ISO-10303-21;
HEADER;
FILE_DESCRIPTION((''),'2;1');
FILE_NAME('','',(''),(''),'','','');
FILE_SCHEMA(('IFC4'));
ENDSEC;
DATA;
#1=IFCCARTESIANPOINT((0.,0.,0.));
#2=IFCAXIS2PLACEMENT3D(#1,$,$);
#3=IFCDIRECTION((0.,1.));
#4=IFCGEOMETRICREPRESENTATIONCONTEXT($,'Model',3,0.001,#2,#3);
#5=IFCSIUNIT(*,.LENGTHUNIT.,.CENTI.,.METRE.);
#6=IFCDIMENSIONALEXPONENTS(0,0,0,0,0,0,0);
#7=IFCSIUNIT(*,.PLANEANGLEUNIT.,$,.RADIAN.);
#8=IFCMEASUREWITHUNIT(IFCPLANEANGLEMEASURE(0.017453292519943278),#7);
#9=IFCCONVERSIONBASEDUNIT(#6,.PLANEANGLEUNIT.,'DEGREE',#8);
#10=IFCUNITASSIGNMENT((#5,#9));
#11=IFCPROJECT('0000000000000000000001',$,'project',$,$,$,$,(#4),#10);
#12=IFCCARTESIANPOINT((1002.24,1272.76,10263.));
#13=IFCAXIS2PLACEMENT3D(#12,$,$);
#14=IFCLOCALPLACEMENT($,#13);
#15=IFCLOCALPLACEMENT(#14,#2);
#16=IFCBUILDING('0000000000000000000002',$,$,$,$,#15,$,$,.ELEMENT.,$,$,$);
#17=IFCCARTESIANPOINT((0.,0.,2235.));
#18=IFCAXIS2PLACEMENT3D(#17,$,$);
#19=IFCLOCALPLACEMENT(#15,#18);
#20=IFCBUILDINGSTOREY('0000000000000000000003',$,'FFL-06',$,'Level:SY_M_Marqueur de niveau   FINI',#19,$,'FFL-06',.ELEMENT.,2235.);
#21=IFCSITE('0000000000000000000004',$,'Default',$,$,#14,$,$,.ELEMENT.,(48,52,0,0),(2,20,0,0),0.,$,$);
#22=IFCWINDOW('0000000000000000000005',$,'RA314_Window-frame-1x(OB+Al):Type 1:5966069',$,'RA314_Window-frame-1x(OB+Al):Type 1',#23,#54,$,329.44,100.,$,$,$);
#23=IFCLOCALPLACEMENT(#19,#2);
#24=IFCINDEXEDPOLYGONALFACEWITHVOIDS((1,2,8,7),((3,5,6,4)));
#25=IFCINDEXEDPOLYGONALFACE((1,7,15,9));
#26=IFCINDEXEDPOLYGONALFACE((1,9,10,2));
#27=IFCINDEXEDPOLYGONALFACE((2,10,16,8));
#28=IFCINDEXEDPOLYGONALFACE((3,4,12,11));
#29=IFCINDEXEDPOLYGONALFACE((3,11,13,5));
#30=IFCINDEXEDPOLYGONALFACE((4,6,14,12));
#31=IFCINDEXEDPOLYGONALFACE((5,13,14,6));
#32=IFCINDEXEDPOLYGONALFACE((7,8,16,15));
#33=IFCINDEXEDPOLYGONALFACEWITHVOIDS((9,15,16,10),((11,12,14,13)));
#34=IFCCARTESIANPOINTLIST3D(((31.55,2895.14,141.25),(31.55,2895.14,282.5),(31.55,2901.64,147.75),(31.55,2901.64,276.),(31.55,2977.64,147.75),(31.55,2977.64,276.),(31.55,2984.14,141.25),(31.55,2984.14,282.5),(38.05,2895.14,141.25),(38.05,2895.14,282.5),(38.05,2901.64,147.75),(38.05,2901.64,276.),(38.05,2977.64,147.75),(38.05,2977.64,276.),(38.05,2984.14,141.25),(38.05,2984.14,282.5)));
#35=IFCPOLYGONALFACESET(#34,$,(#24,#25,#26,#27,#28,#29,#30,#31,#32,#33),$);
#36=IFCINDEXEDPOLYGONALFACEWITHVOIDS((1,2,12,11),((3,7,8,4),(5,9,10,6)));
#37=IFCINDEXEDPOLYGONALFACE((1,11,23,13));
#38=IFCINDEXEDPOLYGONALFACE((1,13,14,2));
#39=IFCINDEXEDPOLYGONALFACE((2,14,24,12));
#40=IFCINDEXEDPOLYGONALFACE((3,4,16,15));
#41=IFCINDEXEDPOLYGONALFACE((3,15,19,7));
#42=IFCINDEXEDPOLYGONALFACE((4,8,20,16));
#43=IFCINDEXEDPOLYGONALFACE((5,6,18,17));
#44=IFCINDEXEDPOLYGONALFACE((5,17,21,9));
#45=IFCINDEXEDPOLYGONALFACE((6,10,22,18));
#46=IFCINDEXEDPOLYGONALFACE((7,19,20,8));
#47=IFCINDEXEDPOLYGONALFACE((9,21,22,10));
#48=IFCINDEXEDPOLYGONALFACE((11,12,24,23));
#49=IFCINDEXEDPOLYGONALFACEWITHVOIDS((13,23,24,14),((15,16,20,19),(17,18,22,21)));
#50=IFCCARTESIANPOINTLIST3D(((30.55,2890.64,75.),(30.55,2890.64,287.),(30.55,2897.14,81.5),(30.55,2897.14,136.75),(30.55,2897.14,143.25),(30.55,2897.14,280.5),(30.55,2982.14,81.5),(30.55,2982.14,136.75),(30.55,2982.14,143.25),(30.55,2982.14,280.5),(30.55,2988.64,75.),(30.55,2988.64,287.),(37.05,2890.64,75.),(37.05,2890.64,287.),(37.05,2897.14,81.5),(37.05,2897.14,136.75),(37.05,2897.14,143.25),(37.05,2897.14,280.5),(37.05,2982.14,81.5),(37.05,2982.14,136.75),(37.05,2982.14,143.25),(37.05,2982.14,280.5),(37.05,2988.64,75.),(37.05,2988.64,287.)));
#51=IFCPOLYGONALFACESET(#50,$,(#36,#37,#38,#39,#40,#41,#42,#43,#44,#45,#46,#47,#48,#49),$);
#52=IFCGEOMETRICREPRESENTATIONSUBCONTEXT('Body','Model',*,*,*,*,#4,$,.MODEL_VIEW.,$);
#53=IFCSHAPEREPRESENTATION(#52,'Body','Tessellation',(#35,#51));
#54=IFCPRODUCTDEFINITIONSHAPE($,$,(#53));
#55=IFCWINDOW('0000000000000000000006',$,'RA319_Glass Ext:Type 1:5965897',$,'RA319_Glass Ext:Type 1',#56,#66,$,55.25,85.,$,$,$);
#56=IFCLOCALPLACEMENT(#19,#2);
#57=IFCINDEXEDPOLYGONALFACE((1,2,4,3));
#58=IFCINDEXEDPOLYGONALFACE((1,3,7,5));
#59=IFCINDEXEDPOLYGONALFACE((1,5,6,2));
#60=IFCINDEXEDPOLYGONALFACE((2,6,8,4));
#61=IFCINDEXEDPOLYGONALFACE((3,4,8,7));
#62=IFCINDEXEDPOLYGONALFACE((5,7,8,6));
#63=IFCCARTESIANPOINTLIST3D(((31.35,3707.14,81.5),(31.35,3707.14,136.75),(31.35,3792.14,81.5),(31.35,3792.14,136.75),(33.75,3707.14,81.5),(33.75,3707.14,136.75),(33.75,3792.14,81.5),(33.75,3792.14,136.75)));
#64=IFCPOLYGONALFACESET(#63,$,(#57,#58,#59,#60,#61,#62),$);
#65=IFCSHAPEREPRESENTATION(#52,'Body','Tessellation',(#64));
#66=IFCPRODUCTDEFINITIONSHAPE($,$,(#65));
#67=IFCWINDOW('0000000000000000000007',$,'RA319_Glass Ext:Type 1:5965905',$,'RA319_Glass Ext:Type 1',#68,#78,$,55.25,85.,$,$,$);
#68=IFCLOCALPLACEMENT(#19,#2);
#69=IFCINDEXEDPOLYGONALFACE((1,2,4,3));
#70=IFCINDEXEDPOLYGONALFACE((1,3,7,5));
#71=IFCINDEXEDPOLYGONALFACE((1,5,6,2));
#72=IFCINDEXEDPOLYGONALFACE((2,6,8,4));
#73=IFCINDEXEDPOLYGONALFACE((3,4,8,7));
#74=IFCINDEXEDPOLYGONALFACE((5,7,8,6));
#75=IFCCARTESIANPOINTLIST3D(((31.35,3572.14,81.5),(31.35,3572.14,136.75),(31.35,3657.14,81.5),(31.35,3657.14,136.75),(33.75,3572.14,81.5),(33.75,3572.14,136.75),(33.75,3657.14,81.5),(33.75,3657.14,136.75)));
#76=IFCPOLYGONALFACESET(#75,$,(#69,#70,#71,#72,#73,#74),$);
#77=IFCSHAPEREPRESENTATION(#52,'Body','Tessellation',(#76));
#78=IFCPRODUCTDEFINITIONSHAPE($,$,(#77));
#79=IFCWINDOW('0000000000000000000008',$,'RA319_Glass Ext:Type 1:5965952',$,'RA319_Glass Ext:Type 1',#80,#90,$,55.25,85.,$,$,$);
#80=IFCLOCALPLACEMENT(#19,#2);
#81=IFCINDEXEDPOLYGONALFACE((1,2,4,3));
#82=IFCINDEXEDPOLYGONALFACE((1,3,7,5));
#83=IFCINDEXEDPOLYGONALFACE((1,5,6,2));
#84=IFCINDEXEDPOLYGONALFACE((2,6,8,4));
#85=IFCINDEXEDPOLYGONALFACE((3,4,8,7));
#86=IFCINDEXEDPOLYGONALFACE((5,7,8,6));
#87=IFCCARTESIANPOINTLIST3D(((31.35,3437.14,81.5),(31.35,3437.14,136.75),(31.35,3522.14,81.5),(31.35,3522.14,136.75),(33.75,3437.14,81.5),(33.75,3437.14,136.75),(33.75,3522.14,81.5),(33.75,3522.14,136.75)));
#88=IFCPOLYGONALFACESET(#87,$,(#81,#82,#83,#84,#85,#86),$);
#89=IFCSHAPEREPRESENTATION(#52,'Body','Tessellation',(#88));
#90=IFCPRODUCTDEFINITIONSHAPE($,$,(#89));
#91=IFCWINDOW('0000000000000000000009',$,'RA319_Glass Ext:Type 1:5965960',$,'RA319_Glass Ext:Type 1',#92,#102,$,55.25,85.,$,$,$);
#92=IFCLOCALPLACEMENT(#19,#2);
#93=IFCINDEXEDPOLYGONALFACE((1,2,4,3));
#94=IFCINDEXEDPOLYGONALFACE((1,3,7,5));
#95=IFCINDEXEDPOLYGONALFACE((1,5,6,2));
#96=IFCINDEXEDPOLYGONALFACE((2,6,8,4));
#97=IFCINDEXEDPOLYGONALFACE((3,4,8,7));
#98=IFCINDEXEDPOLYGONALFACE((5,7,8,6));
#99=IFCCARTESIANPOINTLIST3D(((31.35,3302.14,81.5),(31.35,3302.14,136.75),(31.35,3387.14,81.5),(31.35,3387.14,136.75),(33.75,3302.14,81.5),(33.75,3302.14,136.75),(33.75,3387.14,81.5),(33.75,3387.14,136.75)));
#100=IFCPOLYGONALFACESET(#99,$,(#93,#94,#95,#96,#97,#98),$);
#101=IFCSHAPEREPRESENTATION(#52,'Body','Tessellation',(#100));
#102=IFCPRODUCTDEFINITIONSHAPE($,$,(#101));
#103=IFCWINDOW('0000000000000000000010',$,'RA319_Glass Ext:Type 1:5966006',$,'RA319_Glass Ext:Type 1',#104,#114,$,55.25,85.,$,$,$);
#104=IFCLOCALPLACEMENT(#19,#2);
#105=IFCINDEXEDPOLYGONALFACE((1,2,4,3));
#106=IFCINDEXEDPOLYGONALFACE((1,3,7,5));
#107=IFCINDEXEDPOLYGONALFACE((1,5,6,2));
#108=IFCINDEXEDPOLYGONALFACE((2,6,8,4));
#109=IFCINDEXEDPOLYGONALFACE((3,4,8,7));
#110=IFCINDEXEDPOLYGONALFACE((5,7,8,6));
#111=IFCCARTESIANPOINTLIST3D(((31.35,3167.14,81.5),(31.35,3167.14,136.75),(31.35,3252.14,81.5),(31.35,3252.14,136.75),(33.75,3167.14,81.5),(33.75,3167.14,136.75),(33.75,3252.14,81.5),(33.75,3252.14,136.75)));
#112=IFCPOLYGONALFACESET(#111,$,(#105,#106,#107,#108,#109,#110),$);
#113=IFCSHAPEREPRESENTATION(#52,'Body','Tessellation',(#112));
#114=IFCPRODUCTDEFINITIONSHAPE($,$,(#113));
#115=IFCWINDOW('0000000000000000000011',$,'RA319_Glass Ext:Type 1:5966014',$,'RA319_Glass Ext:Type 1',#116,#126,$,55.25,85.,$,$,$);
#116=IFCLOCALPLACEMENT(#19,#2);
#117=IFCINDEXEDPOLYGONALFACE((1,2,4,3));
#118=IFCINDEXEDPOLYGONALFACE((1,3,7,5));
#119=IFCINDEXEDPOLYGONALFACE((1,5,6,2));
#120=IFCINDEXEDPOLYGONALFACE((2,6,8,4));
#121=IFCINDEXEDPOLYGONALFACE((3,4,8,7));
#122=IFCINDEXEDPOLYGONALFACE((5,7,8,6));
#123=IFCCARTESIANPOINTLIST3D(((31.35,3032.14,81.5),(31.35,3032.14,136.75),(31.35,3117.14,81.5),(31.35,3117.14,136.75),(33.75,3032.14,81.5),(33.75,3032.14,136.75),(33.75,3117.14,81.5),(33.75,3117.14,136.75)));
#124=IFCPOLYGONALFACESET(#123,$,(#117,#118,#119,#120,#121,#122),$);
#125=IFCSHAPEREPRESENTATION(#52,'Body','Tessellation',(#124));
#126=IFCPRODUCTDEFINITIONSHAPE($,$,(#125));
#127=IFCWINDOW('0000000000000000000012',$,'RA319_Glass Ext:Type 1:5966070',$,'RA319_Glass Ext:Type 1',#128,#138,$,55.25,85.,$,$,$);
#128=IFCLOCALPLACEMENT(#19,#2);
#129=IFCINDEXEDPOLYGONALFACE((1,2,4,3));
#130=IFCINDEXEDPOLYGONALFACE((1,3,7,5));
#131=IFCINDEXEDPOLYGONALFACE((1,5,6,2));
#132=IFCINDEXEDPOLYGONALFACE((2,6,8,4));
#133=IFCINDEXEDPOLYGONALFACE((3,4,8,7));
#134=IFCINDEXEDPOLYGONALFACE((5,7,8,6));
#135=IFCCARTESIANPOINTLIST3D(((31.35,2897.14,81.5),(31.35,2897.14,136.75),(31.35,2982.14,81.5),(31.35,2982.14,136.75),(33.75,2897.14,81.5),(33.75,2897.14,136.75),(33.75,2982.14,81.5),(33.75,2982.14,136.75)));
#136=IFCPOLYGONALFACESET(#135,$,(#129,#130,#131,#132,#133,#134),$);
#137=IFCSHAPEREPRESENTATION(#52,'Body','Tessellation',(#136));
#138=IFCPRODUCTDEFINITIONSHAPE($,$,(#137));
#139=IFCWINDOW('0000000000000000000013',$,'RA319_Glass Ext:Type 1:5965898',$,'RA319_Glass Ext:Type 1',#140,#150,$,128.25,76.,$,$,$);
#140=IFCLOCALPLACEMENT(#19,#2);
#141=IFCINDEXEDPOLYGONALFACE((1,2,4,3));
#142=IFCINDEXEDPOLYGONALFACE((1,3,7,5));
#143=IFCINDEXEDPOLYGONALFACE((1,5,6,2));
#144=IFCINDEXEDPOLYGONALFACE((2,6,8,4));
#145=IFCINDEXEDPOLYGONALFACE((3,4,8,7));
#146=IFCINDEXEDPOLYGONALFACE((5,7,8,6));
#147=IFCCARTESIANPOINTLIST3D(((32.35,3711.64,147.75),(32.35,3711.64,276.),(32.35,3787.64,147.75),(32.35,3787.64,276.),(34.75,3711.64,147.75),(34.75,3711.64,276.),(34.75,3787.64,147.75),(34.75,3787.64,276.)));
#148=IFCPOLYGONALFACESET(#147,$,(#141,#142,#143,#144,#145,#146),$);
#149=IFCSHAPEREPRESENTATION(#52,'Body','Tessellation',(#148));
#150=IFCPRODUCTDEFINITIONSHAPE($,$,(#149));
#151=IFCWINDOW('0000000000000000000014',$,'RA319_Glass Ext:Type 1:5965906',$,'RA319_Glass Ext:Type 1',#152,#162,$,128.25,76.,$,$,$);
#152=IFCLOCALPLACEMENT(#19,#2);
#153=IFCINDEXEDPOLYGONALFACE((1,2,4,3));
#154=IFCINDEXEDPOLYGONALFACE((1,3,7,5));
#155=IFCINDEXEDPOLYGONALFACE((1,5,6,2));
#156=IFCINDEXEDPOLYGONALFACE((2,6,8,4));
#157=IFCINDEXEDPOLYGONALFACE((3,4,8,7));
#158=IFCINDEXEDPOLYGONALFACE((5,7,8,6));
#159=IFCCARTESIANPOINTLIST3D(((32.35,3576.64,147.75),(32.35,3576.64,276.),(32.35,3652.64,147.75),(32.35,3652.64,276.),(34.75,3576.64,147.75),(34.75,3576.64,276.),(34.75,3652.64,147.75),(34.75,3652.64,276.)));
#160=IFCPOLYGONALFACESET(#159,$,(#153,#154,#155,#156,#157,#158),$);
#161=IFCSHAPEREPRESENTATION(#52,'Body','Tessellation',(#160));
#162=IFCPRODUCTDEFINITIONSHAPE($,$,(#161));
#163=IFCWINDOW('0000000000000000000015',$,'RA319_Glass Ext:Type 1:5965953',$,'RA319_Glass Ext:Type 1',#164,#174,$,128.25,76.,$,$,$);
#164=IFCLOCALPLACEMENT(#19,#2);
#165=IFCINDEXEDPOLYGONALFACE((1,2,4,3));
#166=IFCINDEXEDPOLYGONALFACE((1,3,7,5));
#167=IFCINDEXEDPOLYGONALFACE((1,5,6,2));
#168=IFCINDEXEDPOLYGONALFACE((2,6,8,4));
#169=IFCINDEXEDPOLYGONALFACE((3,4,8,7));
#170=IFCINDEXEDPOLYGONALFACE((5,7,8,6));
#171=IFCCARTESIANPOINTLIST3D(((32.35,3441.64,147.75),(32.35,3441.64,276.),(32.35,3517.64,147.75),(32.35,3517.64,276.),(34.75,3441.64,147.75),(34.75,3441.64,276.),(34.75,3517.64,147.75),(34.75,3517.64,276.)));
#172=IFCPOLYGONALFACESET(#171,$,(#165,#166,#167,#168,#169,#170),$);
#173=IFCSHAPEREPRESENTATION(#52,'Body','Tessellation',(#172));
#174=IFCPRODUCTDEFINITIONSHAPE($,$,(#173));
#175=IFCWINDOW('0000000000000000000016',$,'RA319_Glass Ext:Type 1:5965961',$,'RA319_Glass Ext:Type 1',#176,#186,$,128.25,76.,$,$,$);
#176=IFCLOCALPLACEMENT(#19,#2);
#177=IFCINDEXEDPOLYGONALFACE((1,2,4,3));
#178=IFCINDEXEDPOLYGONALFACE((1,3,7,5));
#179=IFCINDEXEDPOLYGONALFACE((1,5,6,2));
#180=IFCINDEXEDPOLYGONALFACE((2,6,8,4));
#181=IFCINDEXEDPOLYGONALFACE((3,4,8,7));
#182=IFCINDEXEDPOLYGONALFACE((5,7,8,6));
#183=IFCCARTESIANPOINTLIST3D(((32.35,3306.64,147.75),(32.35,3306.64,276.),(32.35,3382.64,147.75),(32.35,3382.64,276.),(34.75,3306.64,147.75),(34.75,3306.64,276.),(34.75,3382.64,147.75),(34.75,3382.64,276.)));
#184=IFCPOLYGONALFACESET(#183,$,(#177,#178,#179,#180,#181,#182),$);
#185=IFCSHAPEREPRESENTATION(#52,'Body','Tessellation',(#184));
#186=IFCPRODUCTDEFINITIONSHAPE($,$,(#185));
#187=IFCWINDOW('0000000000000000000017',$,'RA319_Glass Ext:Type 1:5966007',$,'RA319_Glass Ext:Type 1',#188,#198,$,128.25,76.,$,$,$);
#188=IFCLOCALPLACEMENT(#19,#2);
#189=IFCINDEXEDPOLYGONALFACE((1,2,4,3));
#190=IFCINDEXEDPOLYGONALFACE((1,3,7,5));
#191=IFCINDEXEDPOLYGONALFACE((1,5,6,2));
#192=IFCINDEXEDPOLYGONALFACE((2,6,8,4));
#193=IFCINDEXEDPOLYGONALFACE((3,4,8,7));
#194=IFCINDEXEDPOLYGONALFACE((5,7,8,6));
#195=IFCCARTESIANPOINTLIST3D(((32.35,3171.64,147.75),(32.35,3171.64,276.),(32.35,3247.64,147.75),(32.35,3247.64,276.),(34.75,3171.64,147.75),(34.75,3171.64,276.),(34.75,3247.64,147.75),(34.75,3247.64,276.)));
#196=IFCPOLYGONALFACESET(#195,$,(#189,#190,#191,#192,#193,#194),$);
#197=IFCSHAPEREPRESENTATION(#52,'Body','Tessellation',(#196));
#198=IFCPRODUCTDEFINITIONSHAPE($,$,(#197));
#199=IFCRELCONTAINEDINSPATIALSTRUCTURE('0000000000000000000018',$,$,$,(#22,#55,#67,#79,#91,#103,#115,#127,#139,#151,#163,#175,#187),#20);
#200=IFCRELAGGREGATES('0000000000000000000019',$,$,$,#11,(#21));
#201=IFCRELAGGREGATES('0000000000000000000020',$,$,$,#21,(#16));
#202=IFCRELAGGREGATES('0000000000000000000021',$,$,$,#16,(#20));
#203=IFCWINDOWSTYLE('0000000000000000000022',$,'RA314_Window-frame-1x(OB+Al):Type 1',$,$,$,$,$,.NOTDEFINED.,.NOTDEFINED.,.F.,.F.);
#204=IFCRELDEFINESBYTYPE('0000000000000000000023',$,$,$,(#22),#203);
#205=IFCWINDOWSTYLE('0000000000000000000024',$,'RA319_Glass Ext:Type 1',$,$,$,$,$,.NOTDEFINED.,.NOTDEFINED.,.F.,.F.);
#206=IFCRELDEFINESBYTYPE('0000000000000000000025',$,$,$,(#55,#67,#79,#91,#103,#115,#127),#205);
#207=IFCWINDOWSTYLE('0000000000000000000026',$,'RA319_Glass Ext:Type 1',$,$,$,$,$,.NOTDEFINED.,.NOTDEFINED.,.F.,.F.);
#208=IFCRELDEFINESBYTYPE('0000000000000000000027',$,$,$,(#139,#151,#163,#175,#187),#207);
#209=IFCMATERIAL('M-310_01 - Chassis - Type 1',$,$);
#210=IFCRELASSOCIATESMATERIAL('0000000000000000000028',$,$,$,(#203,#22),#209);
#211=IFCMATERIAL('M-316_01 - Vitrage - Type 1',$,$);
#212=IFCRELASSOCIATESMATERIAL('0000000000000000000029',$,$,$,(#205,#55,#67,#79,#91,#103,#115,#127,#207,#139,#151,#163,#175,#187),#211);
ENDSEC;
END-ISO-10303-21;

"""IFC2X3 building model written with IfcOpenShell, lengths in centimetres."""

from ifc_helpers import new_model, entity, si_unit, converted_unit, direction, frame, frame_2d, origin, place, context, subcontext, project, spatial, polyline, rectangle, outline, extrude, source, transform, mapped, material, type_object, type_shapes, element, save


model = new_model("IFC2X3")

# Units and contexts
model_context = context("Model", 3, precision=0.001, world=origin(), true_north=direction((0.0, 1.0)))
body_context = subcontext(model_context, "Body", "Model", "MODEL_VIEW")
ifc_project = project(units=[si_unit("LENGTHUNIT", "METRE", prefix="CENTI"), converted_unit("PLANEANGLEUNIT", "DEGREE", entity("IfcPlaneAngleMeasure", 0.017453292519943278), si_unit("PLANEANGLEUNIT", "RADIAN"), dimensions=[0, 0, 0, 0, 0, 0, 0])], contexts=[model_context])

# Site, building, storey
site_placement = place(None, frame((1002.24, 1272.76, 10263.0)))
site = spatial("IfcSite", under=ifc_project, at=site_placement, Name="Default", CompositionType="ELEMENT", RefLatitude=(48, 52, 0, 0), RefLongitude=(2, 20, 0, 0), RefElevation=0.0)
building_placement = place(site_placement, origin())
building = spatial("IfcBuilding", under=site, at=building_placement, CompositionType="ELEMENT")
storey_placement = place(building_placement, frame((0.0, 0.0, 2235.0)))
storey = spatial("IfcBuildingStorey", under=building, at=storey_placement, Name="FFL-06", ObjectType="Level:SY_M_Marqueur de niveau   FINI", LongName="FFL-06", CompositionType="ELEMENT", Elevation=2235.0)

# Windows
ifc_material_1 = material(Name="M-310_01 - Chassis - Type 1")
window_style_1 = type_object("IfcWindowStyle", Name="RA314_Window-frame-1x(OB+Al):Type 1", ConstructionType="NOTDEFINED", OperationType="NOTDEFINED", ParameterTakesPrecedence=False, Sizeable=False, material=ifc_material_1)
shared_shape_1 = source(origin(), body_context, "Body", "SweptSolid", [
    extrude(outline(polyline([(-70.62, -44.5), (70.62, -44.5), (70.62, 44.5), (-70.62, 44.5), (-70.62, -44.5)]), holes=[polyline([(-64.12, -38.0), (-64.12, 38.0), (64.12, 38.0), (64.12, -38.0), (-64.12, -38.0)])]), frame((0.0, 1.0, 136.87), z_axis=(0.0, 1.0, 0.0), x_axis=(0.0, 0.0, -1.0)), (0.0, 0.0, 1.0), 6.5),
    extrude(outline(polyline([(-106.0, -49.0), (106.0, -49.0), (106.0, 49.0), (-106.0, 49.0), (-106.0, -49.0)]), holes=[polyline([(-99.5, -42.5), (-99.5, 42.5), (37.75, 42.5), (37.75, -42.5), (-99.5, -42.5)]), polyline([(44.25, -42.5), (44.25, 42.5), (99.5, 42.5), (99.5, -42.5), (44.25, -42.5)])]), frame((0.0, 0.0, 106.0), z_axis=(0.0, 1.0, 0.0), x_axis=(0.0, 0.0, -1.0)), (0.0, 0.0, 1.0), 6.5),
])
type_shapes(window_style_1, [shared_shape_1])
for number, where, z_axis, x_axis, name in (
    (1, (30.55, 2939.64, 75.0), (0.0, 0.0, 1.0), (0.0, -1.0, 0.0), "RA314_Window-frame-1x(OB+Al):Type 1:5966069"),
):
    element("IfcWindow", number, at=place(storey_placement, frame(where, z_axis=z_axis, x_axis=x_axis)), inside=storey, type_object=window_style_1, material=ifc_material_1, Name=name, ObjectType="RA314_Window-frame-1x(OB+Al):Type 1", OverallHeight=329.44, OverallWidth=100.0, context=body_context, shape_type="MappedRepresentation", body=[
        mapped(shared_shape_1, transform((0.0, 0.0, 0.0), scale=1.0)),
    ])
ifc_material_2 = material(Name="M-316_01 - Vitrage - Type 1")
window_style_2 = type_object("IfcWindowStyle", Name="RA319_Glass Ext:Type 1", ConstructionType="NOTDEFINED", OperationType="NOTDEFINED", ParameterTakesPrecedence=False, Sizeable=False, material=ifc_material_2)
shared_shape_2 = source(origin(), body_context, "Body", "SweptSolid", [
    extrude(rectangle(XDim=85.0, YDim=55.25, at=frame_2d((0.0, 0.0), x_axis=(1.0, 0.0))), frame((0.0, 0.0, 0.0), z_axis=(0.0, 0.0, 1.0), x_axis=(-1.0, 0.0, 0.0)), (0.0, 0.0, 1.0), 2.4),
])
type_shapes(window_style_2, [shared_shape_2])
for number, where, z_axis, x_axis, name in (
    (2, (31.35, 3749.64, 109.12), (1.0, 0.0, 0.0), (0.0, 1.0, 0.0), "RA319_Glass Ext:Type 1:5965897"),
    (3, (31.35, 3614.64, 109.12), (1.0, 0.0, 0.0), (0.0, 1.0, 0.0), "RA319_Glass Ext:Type 1:5965905"),
    (4, (31.35, 3479.64, 109.12), (1.0, 0.0, 0.0), (0.0, 1.0, 0.0), "RA319_Glass Ext:Type 1:5965952"),
    (5, (31.35, 3344.64, 109.12), (1.0, 0.0, 0.0), (0.0, 1.0, 0.0), "RA319_Glass Ext:Type 1:5965960"),
    (6, (31.35, 3209.64, 109.12), (1.0, 0.0, 0.0), (0.0, 1.0, 0.0), "RA319_Glass Ext:Type 1:5966006"),
    (7, (31.35, 3074.64, 109.12), (1.0, 0.0, 0.0), (0.0, 1.0, 0.0), "RA319_Glass Ext:Type 1:5966014"),
    (8, (31.35, 2939.64, 109.12), (1.0, 0.0, 0.0), (0.0, 1.0, 0.0), "RA319_Glass Ext:Type 1:5966070"),
):
    element("IfcWindow", number, at=place(storey_placement, frame(where, z_axis=z_axis, x_axis=x_axis)), inside=storey, type_object=window_style_2, material=ifc_material_2, Name=name, ObjectType="RA319_Glass Ext:Type 1", OverallHeight=55.25, OverallWidth=85.0, context=body_context, shape_type="MappedRepresentation", body=[
        mapped(shared_shape_2, transform((0.0, 0.0, 0.0), scale=1.0)),
    ])
window_style_3 = type_object("IfcWindowStyle", Name="RA319_Glass Ext:Type 1", ConstructionType="NOTDEFINED", OperationType="NOTDEFINED", ParameterTakesPrecedence=False, Sizeable=False, material=ifc_material_2)
shared_shape_3 = source(origin(), body_context, "Body", "SweptSolid", [
    extrude(rectangle(XDim=76.0, YDim=128.25, at=frame_2d((0.0, 0.0), x_axis=(1.0, 0.0))), frame((0.0, 0.0, 0.0), z_axis=(0.0, 0.0, 1.0), x_axis=(-1.0, 0.0, 0.0)), (0.0, 0.0, 1.0), 2.4),
])
type_shapes(window_style_3, [shared_shape_3])
for number, where, z_axis, x_axis, name in (
    (9, (32.35, 3749.64, 211.87), (1.0, 0.0, 0.0), (0.0, 1.0, 0.0), "RA319_Glass Ext:Type 1:5965898"),
    (10, (32.35, 3614.64, 211.87), (1.0, 0.0, 0.0), (0.0, 1.0, 0.0), "RA319_Glass Ext:Type 1:5965906"),
    (11, (32.35, 3479.64, 211.87), (1.0, 0.0, 0.0), (0.0, 1.0, 0.0), "RA319_Glass Ext:Type 1:5965953"),
    (12, (32.35, 3344.64, 211.87), (1.0, 0.0, 0.0), (0.0, 1.0, 0.0), "RA319_Glass Ext:Type 1:5965961"),
    (13, (32.35, 3209.64, 211.87), (1.0, 0.0, 0.0), (0.0, 1.0, 0.0), "RA319_Glass Ext:Type 1:5966007"),
):
    element("IfcWindow", number, at=place(storey_placement, frame(where, z_axis=z_axis, x_axis=x_axis)), inside=storey, type_object=window_style_3, material=ifc_material_2, Name=name, ObjectType="RA319_Glass Ext:Type 1", OverallHeight=128.25, OverallWidth=76.0, context=body_context, shape_type="MappedRepresentation", body=[
        mapped(shared_shape_3, transform((0.0, 0.0, 0.0), scale=1.0)),
    ])

save(model, "model.ifc")
